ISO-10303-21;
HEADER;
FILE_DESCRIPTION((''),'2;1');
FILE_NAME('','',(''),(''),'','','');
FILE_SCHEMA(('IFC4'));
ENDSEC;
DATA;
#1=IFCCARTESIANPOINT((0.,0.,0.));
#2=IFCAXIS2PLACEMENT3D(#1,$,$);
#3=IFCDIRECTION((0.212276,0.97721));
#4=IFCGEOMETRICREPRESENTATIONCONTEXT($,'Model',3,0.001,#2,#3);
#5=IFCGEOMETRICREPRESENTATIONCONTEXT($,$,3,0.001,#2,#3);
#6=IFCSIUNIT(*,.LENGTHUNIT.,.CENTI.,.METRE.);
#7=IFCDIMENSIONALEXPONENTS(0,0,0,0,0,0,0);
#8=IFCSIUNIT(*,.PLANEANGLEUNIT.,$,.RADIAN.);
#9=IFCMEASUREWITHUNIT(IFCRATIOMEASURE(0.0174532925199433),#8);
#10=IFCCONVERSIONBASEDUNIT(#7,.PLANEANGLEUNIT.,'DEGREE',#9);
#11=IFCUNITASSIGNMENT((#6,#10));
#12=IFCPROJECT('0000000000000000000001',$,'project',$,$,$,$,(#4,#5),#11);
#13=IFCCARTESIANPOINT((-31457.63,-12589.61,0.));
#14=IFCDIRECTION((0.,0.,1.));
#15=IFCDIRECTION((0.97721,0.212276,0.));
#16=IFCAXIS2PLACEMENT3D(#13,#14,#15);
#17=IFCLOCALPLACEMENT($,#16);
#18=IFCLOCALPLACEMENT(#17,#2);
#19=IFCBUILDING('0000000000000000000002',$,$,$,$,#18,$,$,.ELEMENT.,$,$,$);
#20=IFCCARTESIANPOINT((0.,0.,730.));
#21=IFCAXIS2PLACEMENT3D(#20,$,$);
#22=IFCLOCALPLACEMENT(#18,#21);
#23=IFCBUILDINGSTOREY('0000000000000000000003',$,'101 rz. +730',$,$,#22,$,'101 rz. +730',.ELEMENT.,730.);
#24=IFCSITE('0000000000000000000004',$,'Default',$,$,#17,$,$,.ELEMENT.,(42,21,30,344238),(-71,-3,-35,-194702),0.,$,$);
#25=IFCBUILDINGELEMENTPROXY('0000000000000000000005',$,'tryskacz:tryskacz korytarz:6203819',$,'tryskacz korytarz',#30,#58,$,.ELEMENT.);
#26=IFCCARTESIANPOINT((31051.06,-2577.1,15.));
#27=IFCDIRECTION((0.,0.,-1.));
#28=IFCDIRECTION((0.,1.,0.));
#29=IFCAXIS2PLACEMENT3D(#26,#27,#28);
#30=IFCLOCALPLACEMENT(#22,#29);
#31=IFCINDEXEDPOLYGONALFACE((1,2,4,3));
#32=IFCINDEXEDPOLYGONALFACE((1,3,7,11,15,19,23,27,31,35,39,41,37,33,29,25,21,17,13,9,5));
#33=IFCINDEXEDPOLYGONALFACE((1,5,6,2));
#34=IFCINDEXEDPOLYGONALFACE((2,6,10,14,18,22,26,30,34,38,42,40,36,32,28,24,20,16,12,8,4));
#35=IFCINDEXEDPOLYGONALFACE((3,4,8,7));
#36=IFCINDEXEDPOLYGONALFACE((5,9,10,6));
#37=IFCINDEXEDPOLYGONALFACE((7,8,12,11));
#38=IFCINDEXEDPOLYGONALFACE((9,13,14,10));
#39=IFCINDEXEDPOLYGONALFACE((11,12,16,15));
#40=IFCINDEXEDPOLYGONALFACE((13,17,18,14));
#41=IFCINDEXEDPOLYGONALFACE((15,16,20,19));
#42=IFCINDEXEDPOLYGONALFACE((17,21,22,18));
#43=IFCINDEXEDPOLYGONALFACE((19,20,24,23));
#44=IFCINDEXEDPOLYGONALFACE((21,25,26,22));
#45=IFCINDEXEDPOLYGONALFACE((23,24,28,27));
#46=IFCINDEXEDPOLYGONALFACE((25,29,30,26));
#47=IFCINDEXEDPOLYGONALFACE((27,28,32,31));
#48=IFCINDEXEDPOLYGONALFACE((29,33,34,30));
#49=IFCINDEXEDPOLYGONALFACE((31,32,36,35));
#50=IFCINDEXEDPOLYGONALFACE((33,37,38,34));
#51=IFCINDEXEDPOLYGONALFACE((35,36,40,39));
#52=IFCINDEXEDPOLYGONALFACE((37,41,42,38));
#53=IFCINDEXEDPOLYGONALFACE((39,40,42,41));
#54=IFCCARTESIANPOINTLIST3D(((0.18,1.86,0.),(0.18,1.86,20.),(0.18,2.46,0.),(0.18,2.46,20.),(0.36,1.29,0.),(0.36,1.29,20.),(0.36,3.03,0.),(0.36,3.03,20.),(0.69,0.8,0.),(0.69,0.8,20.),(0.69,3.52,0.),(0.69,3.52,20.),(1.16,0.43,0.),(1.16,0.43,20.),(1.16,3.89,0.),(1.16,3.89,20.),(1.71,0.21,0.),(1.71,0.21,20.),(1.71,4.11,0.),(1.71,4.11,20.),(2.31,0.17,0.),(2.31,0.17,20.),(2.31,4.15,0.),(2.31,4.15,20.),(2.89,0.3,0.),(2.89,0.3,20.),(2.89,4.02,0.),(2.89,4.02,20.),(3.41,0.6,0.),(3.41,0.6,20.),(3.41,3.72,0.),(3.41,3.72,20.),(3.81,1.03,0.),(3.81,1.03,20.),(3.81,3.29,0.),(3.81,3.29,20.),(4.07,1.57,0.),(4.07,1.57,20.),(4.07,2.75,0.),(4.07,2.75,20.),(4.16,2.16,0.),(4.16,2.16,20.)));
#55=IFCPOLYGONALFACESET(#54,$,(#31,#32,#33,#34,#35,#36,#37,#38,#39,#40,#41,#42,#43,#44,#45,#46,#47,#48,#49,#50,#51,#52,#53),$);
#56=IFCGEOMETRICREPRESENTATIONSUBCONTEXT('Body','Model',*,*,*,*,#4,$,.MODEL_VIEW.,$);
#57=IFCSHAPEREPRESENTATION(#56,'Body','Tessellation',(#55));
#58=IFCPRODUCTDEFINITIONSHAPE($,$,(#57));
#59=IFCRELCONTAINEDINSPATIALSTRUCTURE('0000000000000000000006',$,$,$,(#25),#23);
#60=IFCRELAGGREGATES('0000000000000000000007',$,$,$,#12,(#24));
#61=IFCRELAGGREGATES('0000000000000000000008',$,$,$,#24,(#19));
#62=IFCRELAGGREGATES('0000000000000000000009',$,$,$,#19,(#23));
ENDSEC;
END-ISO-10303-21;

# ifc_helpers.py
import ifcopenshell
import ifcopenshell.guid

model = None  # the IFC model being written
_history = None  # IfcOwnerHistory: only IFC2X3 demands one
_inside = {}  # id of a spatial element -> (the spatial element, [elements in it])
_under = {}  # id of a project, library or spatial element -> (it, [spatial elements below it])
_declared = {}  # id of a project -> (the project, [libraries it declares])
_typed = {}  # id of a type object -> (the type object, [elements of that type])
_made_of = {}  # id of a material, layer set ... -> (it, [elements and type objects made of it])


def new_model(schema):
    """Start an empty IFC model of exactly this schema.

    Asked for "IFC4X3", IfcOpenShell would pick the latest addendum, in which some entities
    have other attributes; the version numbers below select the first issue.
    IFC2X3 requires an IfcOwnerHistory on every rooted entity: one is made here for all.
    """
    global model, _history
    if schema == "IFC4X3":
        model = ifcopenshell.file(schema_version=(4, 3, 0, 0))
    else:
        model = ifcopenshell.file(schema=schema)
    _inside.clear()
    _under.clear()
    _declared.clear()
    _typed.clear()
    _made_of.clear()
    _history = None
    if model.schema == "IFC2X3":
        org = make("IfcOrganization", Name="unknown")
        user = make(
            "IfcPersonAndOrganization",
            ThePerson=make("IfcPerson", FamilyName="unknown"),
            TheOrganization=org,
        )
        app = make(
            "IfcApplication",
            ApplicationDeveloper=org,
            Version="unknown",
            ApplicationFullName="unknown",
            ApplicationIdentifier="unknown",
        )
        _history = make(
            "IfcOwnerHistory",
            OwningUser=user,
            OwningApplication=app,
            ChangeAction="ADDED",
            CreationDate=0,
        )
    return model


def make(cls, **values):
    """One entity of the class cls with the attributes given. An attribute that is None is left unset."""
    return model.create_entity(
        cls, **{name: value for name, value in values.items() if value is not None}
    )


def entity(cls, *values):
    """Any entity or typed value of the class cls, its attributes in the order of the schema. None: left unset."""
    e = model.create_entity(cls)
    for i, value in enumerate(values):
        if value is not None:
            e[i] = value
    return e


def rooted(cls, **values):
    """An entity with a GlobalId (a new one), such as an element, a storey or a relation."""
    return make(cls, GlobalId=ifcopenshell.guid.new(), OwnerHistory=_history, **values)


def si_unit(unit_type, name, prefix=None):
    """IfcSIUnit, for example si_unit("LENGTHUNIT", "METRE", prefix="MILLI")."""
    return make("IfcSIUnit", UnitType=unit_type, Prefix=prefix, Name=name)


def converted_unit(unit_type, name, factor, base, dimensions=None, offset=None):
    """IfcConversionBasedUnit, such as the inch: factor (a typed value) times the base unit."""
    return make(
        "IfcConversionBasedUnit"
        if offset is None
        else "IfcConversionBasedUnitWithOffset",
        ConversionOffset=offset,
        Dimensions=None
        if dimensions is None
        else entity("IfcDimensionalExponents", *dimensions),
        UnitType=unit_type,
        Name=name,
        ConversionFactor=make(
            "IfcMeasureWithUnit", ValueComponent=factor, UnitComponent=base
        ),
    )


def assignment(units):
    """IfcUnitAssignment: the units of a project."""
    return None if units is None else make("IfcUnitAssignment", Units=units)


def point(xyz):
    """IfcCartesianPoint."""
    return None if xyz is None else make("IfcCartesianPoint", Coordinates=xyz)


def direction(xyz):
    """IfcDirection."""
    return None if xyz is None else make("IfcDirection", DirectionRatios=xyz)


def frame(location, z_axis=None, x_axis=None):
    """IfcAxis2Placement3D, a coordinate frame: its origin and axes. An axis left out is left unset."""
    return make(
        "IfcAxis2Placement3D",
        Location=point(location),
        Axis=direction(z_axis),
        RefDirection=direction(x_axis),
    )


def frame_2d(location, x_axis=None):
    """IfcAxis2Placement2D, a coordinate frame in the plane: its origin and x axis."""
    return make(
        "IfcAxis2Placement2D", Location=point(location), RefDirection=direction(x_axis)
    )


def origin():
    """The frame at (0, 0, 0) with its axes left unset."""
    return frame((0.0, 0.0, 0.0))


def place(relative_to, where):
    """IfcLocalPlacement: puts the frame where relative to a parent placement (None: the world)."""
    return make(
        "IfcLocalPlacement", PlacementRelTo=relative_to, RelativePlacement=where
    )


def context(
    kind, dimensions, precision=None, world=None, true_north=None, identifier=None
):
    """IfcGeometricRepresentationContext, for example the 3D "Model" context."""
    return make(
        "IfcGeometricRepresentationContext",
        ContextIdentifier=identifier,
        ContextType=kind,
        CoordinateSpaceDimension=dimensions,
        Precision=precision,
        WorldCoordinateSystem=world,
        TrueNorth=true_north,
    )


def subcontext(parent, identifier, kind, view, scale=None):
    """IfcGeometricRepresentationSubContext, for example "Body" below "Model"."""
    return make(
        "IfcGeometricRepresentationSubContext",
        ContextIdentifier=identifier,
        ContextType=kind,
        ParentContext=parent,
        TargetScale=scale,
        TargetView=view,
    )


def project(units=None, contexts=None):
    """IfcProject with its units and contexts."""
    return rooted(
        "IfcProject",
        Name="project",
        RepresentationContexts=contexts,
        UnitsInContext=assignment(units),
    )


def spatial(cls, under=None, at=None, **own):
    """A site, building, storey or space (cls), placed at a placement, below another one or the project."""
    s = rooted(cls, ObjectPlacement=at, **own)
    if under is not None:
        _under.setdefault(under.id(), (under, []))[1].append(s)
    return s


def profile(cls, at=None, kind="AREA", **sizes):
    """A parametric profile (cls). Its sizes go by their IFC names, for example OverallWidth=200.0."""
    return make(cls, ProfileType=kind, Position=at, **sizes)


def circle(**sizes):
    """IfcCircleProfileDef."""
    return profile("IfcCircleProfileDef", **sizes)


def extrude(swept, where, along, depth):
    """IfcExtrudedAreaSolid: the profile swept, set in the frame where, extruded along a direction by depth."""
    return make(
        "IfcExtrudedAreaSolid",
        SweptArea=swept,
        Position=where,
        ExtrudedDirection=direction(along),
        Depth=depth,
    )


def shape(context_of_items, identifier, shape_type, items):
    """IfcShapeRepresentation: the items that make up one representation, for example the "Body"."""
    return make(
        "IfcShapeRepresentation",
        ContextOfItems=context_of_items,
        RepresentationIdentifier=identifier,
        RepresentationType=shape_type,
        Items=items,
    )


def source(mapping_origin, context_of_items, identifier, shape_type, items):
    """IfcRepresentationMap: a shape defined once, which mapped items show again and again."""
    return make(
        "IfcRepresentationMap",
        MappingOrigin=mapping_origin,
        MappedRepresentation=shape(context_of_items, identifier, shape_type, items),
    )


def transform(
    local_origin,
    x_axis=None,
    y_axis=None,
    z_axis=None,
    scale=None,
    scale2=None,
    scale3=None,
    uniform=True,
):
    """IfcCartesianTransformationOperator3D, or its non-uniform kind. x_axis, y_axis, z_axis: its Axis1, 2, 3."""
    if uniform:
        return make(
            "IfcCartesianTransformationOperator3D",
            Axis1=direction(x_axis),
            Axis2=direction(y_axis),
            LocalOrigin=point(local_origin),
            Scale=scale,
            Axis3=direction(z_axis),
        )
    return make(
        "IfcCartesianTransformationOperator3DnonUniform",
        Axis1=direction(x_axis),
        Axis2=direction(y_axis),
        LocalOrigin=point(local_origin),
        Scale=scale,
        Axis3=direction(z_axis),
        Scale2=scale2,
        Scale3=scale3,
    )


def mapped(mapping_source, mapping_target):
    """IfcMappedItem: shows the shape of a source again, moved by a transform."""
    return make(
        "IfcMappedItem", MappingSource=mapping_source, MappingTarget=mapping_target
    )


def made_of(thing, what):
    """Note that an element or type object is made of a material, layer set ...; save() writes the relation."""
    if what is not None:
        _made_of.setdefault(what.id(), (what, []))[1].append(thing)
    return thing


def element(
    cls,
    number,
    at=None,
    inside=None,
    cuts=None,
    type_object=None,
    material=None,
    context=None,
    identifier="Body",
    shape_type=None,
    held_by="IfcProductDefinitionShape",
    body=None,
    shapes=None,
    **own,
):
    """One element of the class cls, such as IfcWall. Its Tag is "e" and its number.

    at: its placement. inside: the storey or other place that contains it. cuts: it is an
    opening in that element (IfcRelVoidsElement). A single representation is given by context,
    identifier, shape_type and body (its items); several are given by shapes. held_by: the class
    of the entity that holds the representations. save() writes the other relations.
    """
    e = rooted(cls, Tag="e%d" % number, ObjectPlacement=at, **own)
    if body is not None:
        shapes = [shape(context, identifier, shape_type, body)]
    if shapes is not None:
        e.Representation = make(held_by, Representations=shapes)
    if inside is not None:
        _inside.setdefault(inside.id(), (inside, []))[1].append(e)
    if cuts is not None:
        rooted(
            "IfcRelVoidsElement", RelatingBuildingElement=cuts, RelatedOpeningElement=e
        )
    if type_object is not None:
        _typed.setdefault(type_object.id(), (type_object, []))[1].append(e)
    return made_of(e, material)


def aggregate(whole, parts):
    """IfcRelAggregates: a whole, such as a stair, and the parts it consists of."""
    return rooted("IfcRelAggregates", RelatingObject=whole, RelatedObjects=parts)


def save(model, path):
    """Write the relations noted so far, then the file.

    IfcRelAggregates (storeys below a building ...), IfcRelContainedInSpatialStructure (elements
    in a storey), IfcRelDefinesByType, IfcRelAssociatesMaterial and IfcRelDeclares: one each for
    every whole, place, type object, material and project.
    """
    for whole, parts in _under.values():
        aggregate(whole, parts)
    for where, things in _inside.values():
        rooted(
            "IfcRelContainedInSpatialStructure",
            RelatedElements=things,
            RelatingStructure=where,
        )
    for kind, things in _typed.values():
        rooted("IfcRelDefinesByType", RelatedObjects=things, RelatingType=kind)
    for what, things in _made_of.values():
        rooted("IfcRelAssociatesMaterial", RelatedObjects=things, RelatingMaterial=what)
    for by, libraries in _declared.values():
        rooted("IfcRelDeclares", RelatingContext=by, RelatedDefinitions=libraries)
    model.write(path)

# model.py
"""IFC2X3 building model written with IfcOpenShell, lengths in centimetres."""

from ifc_helpers import new_model, entity, si_unit, converted_unit, direction, frame, frame_2d, origin, place, context, subcontext, project, spatial, circle, extrude, source, transform, mapped, element, save


model = new_model("IFC2X3")

# Units and contexts
model_context = context("Model", 3, precision=0.001, world=origin(), true_north=direction((0.212276, 0.97721)))
context_of_model = context(None, 3, precision=0.001, world=origin(), true_north=direction((0.212276, 0.97721)))
body_context = subcontext(model_context, "Body", "Model", "MODEL_VIEW")
ifc_project = project(units=[si_unit("LENGTHUNIT", "METRE", prefix="CENTI"), converted_unit("PLANEANGLEUNIT", "DEGREE", entity("IfcRatioMeasure", 0.0174532925199433), si_unit("PLANEANGLEUNIT", "RADIAN"), dimensions=[0, 0, 0, 0, 0, 0, 0])], contexts=[model_context, context_of_model])

# Site, building, storey
site_placement = place(None, frame((-31457.63, -12589.61, 0.0), z_axis=(0.0, 0.0, 1.0), x_axis=(0.97721, 0.212276, 0.0)))
site = spatial("IfcSite", under=ifc_project, at=site_placement, Name="Default", CompositionType="ELEMENT", RefLatitude=(42, 21, 30, 344238), RefLongitude=(-71, -3, -35, -194702), RefElevation=0.0)
building_placement = place(site_placement, origin())
building = spatial("IfcBuilding", under=site, at=building_placement, CompositionType="ELEMENT")
storey_placement = place(building_placement, frame((0.0, 0.0, 730.0)))
storey = spatial("IfcBuildingStorey", under=building, at=storey_placement, Name="101 rz. +730", LongName="101 rz. +730", CompositionType="ELEMENT", Elevation=730.0)

# Building element proxy
shared_shape_1 = source(origin(), body_context, "Body", "SweptSolid", [
    extrude(circle(Radius=2.0, at=frame_2d((0.0, 0.0), x_axis=(1.0, 0.0))), frame((2.16, 2.16, 0.0)), (0.0, 0.0, 1.0), 20.0),
])
for number, where, z_axis, x_axis, name in (
    (1, (31051.06, -2577.1, 15.0), (0.0, 0.0, -1.0), (0.0, 1.0, 0.0), "tryskacz:tryskacz korytarz:6203819"),
):
    element("IfcBuildingElementProxy", number, at=place(storey_placement, frame(where, z_axis=z_axis, x_axis=x_axis)), inside=storey, Name=name, ObjectType="tryskacz korytarz", CompositionType="ELEMENT", context=body_context, shape_type="MappedRepresentation", body=[
        mapped(shared_shape_1, transform((0.0, 0.0, 0.0), scale=1.0)),
    ])

save(model, "model.ifc")
